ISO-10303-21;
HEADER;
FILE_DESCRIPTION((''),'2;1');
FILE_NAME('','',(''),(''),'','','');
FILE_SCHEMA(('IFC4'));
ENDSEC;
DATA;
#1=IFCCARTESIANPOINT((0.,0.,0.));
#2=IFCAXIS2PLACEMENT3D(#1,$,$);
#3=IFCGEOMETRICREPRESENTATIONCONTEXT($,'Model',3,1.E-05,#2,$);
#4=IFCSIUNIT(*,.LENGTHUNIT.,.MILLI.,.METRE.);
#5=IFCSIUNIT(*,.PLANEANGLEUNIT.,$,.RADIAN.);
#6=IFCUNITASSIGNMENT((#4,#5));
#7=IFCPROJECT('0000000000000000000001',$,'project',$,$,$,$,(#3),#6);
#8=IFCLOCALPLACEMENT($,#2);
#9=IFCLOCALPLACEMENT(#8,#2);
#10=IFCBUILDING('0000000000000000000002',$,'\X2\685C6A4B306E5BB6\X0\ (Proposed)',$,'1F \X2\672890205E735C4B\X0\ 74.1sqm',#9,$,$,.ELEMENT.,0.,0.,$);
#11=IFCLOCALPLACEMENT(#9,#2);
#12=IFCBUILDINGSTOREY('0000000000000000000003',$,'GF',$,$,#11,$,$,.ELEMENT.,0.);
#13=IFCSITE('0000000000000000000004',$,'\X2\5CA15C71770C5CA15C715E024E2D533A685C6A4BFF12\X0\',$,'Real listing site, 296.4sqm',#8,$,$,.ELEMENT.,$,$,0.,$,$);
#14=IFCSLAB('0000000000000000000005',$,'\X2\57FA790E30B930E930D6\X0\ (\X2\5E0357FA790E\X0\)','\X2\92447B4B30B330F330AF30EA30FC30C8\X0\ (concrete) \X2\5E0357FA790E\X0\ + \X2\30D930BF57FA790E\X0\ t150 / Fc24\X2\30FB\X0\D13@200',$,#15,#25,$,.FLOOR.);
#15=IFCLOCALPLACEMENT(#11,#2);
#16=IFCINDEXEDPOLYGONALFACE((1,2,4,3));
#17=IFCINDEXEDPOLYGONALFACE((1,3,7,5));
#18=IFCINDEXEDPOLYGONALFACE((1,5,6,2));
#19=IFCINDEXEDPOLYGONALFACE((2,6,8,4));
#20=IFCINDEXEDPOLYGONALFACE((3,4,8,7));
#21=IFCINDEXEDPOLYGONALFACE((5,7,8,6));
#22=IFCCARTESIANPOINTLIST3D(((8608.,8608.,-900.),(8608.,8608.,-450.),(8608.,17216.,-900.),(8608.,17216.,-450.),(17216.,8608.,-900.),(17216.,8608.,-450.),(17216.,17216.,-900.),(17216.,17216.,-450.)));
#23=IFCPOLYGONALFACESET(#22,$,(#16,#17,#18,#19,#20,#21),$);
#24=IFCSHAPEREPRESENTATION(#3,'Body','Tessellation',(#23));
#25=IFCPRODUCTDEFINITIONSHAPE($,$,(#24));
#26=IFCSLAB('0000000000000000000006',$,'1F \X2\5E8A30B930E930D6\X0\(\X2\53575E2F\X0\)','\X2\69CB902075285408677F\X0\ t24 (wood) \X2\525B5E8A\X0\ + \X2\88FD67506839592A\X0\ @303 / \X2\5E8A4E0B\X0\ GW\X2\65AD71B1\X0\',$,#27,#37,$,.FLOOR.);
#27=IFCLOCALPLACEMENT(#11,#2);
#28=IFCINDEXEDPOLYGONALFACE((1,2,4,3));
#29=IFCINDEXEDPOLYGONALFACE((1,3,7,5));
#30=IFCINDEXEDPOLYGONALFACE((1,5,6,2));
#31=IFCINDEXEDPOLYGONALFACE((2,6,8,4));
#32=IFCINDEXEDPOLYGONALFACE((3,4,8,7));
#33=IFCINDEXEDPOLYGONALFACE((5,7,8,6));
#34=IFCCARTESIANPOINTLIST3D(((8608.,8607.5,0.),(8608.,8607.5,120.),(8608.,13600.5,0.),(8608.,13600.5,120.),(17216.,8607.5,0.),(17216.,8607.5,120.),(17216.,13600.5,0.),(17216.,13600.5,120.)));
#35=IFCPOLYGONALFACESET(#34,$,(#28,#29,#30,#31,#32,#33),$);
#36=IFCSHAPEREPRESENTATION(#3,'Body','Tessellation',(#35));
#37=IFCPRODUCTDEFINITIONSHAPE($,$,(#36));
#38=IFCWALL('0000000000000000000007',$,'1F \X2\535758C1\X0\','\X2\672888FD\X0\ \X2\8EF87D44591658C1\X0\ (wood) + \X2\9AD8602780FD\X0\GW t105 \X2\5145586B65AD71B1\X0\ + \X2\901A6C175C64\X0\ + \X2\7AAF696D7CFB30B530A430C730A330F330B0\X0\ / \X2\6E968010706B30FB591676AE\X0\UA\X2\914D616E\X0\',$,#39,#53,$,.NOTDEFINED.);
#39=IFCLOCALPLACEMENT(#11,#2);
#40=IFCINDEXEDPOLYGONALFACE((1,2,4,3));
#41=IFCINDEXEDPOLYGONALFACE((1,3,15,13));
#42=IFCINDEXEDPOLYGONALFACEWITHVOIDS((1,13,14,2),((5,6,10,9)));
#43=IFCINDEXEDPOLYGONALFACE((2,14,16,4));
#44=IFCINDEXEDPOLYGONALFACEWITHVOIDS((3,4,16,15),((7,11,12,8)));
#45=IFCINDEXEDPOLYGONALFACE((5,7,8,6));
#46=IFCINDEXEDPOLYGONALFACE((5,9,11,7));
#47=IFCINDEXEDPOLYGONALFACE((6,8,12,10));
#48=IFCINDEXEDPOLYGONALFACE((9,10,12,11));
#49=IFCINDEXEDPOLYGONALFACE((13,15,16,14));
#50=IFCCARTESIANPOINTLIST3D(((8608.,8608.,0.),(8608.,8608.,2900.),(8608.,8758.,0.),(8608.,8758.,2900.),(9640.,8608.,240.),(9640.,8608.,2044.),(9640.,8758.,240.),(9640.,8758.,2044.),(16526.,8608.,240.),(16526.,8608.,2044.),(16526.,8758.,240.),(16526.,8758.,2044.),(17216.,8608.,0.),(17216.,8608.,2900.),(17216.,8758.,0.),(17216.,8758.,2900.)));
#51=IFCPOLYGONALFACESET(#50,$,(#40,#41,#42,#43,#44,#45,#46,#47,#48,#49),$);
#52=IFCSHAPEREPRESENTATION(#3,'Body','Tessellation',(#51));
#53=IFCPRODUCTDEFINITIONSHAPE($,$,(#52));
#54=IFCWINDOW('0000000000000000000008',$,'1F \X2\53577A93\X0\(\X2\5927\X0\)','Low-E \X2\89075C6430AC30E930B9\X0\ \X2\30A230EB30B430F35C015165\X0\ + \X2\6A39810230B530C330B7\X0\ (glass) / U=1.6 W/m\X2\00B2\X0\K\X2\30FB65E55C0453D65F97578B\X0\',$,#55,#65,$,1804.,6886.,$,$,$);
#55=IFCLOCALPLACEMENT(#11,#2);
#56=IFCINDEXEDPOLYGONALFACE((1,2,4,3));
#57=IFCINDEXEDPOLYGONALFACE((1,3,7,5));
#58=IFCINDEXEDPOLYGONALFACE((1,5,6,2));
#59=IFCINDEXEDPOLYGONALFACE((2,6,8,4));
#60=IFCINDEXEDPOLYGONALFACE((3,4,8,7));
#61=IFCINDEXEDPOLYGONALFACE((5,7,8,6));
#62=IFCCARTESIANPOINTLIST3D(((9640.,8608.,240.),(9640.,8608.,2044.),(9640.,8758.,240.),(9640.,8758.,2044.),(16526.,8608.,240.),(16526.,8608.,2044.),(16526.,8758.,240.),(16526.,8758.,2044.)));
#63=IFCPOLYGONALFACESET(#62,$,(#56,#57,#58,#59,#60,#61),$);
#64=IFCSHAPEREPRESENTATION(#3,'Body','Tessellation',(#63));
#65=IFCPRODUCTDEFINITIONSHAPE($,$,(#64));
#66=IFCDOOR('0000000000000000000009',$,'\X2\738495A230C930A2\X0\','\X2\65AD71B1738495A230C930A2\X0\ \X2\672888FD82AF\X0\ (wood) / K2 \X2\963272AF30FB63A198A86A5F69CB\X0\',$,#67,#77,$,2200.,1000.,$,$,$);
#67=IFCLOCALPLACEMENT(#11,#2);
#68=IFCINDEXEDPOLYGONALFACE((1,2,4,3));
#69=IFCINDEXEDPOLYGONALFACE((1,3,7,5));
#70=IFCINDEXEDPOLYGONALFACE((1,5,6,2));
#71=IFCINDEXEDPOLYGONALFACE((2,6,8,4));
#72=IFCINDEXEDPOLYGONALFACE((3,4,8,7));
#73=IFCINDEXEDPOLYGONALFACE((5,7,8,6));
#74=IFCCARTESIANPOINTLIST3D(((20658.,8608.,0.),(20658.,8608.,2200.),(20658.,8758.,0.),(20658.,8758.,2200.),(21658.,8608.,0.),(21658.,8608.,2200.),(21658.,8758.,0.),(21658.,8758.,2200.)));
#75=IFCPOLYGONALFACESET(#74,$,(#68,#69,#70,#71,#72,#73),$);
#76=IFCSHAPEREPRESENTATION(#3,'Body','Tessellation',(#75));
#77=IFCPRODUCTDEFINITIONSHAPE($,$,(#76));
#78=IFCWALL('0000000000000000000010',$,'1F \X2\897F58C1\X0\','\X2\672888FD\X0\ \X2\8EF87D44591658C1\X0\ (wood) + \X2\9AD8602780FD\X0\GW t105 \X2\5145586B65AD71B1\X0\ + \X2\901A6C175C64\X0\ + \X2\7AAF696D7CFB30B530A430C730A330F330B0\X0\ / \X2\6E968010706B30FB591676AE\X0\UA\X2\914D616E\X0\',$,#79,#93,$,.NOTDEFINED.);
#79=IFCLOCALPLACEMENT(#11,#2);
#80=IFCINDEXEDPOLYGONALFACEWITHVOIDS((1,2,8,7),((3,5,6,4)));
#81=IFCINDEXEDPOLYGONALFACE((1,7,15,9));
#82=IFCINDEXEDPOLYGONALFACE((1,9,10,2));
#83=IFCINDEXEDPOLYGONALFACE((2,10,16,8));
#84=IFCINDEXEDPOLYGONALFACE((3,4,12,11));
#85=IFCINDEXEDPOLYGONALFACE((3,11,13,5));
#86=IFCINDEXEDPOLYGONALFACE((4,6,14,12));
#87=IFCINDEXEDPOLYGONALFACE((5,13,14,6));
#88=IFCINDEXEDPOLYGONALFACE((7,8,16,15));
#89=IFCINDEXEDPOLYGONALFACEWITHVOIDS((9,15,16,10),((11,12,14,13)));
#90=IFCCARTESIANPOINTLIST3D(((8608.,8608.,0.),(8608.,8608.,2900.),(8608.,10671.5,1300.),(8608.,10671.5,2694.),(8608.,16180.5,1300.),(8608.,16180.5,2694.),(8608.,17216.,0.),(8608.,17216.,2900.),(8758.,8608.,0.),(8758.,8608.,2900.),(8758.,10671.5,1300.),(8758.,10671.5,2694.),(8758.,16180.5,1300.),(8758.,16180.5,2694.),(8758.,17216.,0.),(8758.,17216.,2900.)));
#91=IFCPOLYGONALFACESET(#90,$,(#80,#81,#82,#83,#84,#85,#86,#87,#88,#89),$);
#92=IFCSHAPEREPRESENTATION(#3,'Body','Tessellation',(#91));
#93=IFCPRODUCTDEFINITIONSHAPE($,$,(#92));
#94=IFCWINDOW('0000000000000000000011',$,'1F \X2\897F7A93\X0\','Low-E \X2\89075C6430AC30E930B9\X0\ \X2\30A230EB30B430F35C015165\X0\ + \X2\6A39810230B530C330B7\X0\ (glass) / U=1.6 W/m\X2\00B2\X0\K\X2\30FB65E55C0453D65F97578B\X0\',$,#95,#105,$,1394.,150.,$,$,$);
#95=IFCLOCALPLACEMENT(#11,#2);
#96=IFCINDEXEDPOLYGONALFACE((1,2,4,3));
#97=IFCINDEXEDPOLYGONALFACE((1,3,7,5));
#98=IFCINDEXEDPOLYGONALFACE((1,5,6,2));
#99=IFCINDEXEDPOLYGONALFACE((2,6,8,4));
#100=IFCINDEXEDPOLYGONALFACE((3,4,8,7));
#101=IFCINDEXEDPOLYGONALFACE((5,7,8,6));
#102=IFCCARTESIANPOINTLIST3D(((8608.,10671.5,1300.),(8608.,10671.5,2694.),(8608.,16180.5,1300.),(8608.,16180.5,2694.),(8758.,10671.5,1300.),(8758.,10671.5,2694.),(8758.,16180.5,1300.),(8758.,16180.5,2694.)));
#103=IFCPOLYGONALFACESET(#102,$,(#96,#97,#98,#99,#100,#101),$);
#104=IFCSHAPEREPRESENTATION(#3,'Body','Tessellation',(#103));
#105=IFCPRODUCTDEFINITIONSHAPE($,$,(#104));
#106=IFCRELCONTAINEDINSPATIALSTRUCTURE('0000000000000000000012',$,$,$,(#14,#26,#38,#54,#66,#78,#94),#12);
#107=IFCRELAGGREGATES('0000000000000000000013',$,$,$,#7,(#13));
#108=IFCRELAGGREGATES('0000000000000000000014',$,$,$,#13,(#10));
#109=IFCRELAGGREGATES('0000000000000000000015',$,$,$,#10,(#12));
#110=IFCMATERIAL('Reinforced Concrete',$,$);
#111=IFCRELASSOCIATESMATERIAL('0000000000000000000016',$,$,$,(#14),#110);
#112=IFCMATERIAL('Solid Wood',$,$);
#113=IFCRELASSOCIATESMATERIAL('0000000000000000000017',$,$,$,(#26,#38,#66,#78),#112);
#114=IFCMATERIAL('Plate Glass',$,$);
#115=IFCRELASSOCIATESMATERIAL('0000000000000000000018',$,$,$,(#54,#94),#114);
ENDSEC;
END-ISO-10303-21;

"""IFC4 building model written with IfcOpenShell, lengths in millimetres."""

from ifc_helpers import new_model, si_unit, frame, frame_2d, origin, place, context, project, spatial, rectangle, extrude, material, element, fill, save


model = new_model("IFC4")

# Units and contexts
model_context = context("Model", 3, precision=1e-05, world=origin())
ifc_project = project(units=[si_unit("LENGTHUNIT", "METRE", prefix="MILLI"), si_unit("PLANEANGLEUNIT", "RADIAN")], contexts=[model_context])

# Site, building, storey
site_placement = place(None, origin())
site = spatial("IfcSite", under=ifc_project, at=site_placement, Name="岡山県岡山市中区桜橋２", ObjectType="Real listing site, 296.4sqm", CompositionType="ELEMENT", RefElevation=0.0)
building_placement = place(site_placement, origin())
building = spatial("IfcBuilding", under=site, at=building_placement, Name="桜橋の家 (Proposed)", ObjectType="1F 木造平屋 74.1sqm", CompositionType="ELEMENT", ElevationOfRefHeight=0.0, ElevationOfTerrain=0.0)
storey_placement = place(building_placement, origin())
storey = spatial("IfcBuildingStorey", under=building, at=storey_placement, Name="GF", CompositionType="ELEMENT", Elevation=0.0)

# Slabs
ifc_material_1 = material(Name="Reinforced Concrete")
slab_1_placement = place(storey_placement, frame((4304.0, 4304.0, -450.0)))
element("IfcSlab", 1, at=slab_1_placement, inside=storey, material=ifc_material_1, Name="基礎スラブ (布基礎)", Description="鉄筋コンクリート (concrete) 布基礎 + ベタ基礎 t150 / Fc24・D13@200", PredefinedType="FLOOR", context=model_context, shape_type="SweptSolid", body=[
    extrude(rectangle(XDim=8608.0, YDim=8608.0, at=frame_2d((4304.0, 4304.0))), frame((4304.0, 4304.0, -450.0)), (0.0, 0.0, 1.0), 450.0),
])
ifc_material_2 = material(Name="Solid Wood")
slab_2_placement = place(storey_placement, frame((4304.0, 4304.0, 0.0)))
element("IfcSlab", 2, at=slab_2_placement, inside=storey, material=ifc_material_2, Name="1F 床スラブ(南帯)", Description="構造用合板 t24 (wood) 剛床 + 製材根太 @303 / 床下 GW断熱", PredefinedType="FLOOR", context=model_context, shape_type="SweptSolid", body=[
    extrude(rectangle(XDim=8608.0, YDim=4993.0, at=frame_2d((4304.0, 2496.0))), frame((4304.0, 4304.0, 0.0)), (0.0, 0.0, 1.0), 120.0),
])

# Wall, openings, window, door
wall_1_placement = place(storey_placement, frame((4304.0, 4304.0, 0.0)))
wall_1 = element("IfcWall", 3, at=wall_1_placement, inside=storey, material=ifc_material_2, Name="1F 南壁", Description="木製 軸組外壁 (wood) + 高性能GW t105 充填断熱 + 通気層 + 窯業系サイディング / 準耐火・外皮UA配慮", PredefinedType="NOTDEFINED", context=model_context, shape_type="SweptSolid", body=[
    extrude(rectangle(XDim=8608.0, YDim=150.0, at=frame_2d((4304.0, 75.0))), frame((4304.0, 4304.0, 0.0)), (0.0, 0.0, 1.0), 2900.0),
])
opening_1_placement = place(storey_placement, frame((4820.0, 4304.0, 120.0)))
opening_1 = element("IfcOpeningElement", 4, at=opening_1_placement, cuts=wall_1, PredefinedType="NOTDEFINED", context=model_context, shape_type="SweptSolid", body=[
    extrude(rectangle(XDim=6886.0, YDim=150.0, at=frame_2d((3443.0, 75.0))), frame((4820.0, 4304.0, 120.0)), (0.0, 0.0, 1.0), 1804.0),
])
opening_2_placement = place(storey_placement, frame((10329.0, 4304.0, 0.0)))
opening_2 = element("IfcOpeningElement", 5, at=opening_2_placement, cuts=wall_1, PredefinedType="NOTDEFINED", context=model_context, shape_type="SweptSolid", body=[
    extrude(rectangle(XDim=1000.0, YDim=150.0, at=frame_2d((500.0, 75.0))), frame((10329.0, 4304.0, 0.0)), (0.0, 0.0, 1.0), 2200.0),
])
ifc_material_3 = material(Name="Plate Glass")
window_1_placement = place(storey_placement, frame((4820.0, 4304.0, 120.0)))
window_1 = element("IfcWindow", 6, at=window_1_placement, inside=storey, material=ifc_material_3, Name="1F 南窓(大)", Description="Low-E 複層ガラス アルゴン封入 + 樹脂サッシ (glass) / U=1.6 W/m²K・日射取得型", OverallHeight=1804.0, OverallWidth=6886.0, context=model_context, shape_type="SweptSolid", body=[
    extrude(rectangle(XDim=6886.0, YDim=150.0, at=frame_2d((3443.0, 75.0))), frame((4820.0, 4304.0, 120.0)), (0.0, 0.0, 1.0), 1804.0),
])
fill(opening_1, window_1)
door_placement = place(storey_placement, frame((10329.0, 4304.0, 0.0)))
door = element("IfcDoor", 7, at=door_placement, inside=storey, material=ifc_material_2, Name="玄関ドア", Description="断熱玄関ドア 木製芯 (wood) / K2 防犯・採風機構", OverallHeight=2200.0, OverallWidth=1000.0, context=model_context, shape_type="SweptSolid", body=[
    extrude(rectangle(XDim=1000.0, YDim=150.0, at=frame_2d((500.0, 75.0))), frame((10329.0, 4304.0, 0.0)), (0.0, 0.0, 1.0), 2200.0),
])
fill(opening_2, door)

# Wall, opening, window
wall_2_placement = place(storey_placement, frame((4304.0, 4304.0, 0.0)))
wall_2 = element("IfcWall", 8, at=wall_2_placement, inside=storey, material=ifc_material_2, Name="1F 西壁", Description="木製 軸組外壁 (wood) + 高性能GW t105 充填断熱 + 通気層 + 窯業系サイディング / 準耐火・外皮UA配慮", PredefinedType="NOTDEFINED", context=model_context, shape_type="SweptSolid", body=[
    extrude(rectangle(XDim=150.0, YDim=8608.0, at=frame_2d((75.0, 4304.0))), frame((4304.0, 4304.0, 0.0)), (0.0, 0.0, 1.0), 2900.0),
])
opening_3_placement = place(storey_placement, frame((4304.0, 5336.0, 650.0)))
opening_3 = element("IfcOpeningElement", 9, at=opening_3_placement, cuts=wall_2, PredefinedType="NOTDEFINED", context=model_context, shape_type="SweptSolid", body=[
    extrude(rectangle(XDim=150.0, YDim=5509.0, at=frame_2d((75.0, 2754.0))), frame((4304.0, 5336.0, 650.0)), (0.0, 0.0, 1.0), 1394.0),
])
window_2_placement = place(storey_placement, frame((4304.0, 5336.0, 650.0)))
window_2 = element("IfcWindow", 10, at=window_2_placement, inside=storey, material=ifc_material_3, Name="1F 西窓", Description="Low-E 複層ガラス アルゴン封入 + 樹脂サッシ (glass) / U=1.6 W/m²K・日射取得型", OverallHeight=1394.0, OverallWidth=150.0, context=model_context, shape_type="SweptSolid", body=[
    extrude(rectangle(XDim=150.0, YDim=5509.0, at=frame_2d((75.0, 2754.0))), frame((4304.0, 5336.0, 650.0)), (0.0, 0.0, 1.0), 1394.0),
])
fill(opening_3, window_2)

save(model, "model.ifc")
